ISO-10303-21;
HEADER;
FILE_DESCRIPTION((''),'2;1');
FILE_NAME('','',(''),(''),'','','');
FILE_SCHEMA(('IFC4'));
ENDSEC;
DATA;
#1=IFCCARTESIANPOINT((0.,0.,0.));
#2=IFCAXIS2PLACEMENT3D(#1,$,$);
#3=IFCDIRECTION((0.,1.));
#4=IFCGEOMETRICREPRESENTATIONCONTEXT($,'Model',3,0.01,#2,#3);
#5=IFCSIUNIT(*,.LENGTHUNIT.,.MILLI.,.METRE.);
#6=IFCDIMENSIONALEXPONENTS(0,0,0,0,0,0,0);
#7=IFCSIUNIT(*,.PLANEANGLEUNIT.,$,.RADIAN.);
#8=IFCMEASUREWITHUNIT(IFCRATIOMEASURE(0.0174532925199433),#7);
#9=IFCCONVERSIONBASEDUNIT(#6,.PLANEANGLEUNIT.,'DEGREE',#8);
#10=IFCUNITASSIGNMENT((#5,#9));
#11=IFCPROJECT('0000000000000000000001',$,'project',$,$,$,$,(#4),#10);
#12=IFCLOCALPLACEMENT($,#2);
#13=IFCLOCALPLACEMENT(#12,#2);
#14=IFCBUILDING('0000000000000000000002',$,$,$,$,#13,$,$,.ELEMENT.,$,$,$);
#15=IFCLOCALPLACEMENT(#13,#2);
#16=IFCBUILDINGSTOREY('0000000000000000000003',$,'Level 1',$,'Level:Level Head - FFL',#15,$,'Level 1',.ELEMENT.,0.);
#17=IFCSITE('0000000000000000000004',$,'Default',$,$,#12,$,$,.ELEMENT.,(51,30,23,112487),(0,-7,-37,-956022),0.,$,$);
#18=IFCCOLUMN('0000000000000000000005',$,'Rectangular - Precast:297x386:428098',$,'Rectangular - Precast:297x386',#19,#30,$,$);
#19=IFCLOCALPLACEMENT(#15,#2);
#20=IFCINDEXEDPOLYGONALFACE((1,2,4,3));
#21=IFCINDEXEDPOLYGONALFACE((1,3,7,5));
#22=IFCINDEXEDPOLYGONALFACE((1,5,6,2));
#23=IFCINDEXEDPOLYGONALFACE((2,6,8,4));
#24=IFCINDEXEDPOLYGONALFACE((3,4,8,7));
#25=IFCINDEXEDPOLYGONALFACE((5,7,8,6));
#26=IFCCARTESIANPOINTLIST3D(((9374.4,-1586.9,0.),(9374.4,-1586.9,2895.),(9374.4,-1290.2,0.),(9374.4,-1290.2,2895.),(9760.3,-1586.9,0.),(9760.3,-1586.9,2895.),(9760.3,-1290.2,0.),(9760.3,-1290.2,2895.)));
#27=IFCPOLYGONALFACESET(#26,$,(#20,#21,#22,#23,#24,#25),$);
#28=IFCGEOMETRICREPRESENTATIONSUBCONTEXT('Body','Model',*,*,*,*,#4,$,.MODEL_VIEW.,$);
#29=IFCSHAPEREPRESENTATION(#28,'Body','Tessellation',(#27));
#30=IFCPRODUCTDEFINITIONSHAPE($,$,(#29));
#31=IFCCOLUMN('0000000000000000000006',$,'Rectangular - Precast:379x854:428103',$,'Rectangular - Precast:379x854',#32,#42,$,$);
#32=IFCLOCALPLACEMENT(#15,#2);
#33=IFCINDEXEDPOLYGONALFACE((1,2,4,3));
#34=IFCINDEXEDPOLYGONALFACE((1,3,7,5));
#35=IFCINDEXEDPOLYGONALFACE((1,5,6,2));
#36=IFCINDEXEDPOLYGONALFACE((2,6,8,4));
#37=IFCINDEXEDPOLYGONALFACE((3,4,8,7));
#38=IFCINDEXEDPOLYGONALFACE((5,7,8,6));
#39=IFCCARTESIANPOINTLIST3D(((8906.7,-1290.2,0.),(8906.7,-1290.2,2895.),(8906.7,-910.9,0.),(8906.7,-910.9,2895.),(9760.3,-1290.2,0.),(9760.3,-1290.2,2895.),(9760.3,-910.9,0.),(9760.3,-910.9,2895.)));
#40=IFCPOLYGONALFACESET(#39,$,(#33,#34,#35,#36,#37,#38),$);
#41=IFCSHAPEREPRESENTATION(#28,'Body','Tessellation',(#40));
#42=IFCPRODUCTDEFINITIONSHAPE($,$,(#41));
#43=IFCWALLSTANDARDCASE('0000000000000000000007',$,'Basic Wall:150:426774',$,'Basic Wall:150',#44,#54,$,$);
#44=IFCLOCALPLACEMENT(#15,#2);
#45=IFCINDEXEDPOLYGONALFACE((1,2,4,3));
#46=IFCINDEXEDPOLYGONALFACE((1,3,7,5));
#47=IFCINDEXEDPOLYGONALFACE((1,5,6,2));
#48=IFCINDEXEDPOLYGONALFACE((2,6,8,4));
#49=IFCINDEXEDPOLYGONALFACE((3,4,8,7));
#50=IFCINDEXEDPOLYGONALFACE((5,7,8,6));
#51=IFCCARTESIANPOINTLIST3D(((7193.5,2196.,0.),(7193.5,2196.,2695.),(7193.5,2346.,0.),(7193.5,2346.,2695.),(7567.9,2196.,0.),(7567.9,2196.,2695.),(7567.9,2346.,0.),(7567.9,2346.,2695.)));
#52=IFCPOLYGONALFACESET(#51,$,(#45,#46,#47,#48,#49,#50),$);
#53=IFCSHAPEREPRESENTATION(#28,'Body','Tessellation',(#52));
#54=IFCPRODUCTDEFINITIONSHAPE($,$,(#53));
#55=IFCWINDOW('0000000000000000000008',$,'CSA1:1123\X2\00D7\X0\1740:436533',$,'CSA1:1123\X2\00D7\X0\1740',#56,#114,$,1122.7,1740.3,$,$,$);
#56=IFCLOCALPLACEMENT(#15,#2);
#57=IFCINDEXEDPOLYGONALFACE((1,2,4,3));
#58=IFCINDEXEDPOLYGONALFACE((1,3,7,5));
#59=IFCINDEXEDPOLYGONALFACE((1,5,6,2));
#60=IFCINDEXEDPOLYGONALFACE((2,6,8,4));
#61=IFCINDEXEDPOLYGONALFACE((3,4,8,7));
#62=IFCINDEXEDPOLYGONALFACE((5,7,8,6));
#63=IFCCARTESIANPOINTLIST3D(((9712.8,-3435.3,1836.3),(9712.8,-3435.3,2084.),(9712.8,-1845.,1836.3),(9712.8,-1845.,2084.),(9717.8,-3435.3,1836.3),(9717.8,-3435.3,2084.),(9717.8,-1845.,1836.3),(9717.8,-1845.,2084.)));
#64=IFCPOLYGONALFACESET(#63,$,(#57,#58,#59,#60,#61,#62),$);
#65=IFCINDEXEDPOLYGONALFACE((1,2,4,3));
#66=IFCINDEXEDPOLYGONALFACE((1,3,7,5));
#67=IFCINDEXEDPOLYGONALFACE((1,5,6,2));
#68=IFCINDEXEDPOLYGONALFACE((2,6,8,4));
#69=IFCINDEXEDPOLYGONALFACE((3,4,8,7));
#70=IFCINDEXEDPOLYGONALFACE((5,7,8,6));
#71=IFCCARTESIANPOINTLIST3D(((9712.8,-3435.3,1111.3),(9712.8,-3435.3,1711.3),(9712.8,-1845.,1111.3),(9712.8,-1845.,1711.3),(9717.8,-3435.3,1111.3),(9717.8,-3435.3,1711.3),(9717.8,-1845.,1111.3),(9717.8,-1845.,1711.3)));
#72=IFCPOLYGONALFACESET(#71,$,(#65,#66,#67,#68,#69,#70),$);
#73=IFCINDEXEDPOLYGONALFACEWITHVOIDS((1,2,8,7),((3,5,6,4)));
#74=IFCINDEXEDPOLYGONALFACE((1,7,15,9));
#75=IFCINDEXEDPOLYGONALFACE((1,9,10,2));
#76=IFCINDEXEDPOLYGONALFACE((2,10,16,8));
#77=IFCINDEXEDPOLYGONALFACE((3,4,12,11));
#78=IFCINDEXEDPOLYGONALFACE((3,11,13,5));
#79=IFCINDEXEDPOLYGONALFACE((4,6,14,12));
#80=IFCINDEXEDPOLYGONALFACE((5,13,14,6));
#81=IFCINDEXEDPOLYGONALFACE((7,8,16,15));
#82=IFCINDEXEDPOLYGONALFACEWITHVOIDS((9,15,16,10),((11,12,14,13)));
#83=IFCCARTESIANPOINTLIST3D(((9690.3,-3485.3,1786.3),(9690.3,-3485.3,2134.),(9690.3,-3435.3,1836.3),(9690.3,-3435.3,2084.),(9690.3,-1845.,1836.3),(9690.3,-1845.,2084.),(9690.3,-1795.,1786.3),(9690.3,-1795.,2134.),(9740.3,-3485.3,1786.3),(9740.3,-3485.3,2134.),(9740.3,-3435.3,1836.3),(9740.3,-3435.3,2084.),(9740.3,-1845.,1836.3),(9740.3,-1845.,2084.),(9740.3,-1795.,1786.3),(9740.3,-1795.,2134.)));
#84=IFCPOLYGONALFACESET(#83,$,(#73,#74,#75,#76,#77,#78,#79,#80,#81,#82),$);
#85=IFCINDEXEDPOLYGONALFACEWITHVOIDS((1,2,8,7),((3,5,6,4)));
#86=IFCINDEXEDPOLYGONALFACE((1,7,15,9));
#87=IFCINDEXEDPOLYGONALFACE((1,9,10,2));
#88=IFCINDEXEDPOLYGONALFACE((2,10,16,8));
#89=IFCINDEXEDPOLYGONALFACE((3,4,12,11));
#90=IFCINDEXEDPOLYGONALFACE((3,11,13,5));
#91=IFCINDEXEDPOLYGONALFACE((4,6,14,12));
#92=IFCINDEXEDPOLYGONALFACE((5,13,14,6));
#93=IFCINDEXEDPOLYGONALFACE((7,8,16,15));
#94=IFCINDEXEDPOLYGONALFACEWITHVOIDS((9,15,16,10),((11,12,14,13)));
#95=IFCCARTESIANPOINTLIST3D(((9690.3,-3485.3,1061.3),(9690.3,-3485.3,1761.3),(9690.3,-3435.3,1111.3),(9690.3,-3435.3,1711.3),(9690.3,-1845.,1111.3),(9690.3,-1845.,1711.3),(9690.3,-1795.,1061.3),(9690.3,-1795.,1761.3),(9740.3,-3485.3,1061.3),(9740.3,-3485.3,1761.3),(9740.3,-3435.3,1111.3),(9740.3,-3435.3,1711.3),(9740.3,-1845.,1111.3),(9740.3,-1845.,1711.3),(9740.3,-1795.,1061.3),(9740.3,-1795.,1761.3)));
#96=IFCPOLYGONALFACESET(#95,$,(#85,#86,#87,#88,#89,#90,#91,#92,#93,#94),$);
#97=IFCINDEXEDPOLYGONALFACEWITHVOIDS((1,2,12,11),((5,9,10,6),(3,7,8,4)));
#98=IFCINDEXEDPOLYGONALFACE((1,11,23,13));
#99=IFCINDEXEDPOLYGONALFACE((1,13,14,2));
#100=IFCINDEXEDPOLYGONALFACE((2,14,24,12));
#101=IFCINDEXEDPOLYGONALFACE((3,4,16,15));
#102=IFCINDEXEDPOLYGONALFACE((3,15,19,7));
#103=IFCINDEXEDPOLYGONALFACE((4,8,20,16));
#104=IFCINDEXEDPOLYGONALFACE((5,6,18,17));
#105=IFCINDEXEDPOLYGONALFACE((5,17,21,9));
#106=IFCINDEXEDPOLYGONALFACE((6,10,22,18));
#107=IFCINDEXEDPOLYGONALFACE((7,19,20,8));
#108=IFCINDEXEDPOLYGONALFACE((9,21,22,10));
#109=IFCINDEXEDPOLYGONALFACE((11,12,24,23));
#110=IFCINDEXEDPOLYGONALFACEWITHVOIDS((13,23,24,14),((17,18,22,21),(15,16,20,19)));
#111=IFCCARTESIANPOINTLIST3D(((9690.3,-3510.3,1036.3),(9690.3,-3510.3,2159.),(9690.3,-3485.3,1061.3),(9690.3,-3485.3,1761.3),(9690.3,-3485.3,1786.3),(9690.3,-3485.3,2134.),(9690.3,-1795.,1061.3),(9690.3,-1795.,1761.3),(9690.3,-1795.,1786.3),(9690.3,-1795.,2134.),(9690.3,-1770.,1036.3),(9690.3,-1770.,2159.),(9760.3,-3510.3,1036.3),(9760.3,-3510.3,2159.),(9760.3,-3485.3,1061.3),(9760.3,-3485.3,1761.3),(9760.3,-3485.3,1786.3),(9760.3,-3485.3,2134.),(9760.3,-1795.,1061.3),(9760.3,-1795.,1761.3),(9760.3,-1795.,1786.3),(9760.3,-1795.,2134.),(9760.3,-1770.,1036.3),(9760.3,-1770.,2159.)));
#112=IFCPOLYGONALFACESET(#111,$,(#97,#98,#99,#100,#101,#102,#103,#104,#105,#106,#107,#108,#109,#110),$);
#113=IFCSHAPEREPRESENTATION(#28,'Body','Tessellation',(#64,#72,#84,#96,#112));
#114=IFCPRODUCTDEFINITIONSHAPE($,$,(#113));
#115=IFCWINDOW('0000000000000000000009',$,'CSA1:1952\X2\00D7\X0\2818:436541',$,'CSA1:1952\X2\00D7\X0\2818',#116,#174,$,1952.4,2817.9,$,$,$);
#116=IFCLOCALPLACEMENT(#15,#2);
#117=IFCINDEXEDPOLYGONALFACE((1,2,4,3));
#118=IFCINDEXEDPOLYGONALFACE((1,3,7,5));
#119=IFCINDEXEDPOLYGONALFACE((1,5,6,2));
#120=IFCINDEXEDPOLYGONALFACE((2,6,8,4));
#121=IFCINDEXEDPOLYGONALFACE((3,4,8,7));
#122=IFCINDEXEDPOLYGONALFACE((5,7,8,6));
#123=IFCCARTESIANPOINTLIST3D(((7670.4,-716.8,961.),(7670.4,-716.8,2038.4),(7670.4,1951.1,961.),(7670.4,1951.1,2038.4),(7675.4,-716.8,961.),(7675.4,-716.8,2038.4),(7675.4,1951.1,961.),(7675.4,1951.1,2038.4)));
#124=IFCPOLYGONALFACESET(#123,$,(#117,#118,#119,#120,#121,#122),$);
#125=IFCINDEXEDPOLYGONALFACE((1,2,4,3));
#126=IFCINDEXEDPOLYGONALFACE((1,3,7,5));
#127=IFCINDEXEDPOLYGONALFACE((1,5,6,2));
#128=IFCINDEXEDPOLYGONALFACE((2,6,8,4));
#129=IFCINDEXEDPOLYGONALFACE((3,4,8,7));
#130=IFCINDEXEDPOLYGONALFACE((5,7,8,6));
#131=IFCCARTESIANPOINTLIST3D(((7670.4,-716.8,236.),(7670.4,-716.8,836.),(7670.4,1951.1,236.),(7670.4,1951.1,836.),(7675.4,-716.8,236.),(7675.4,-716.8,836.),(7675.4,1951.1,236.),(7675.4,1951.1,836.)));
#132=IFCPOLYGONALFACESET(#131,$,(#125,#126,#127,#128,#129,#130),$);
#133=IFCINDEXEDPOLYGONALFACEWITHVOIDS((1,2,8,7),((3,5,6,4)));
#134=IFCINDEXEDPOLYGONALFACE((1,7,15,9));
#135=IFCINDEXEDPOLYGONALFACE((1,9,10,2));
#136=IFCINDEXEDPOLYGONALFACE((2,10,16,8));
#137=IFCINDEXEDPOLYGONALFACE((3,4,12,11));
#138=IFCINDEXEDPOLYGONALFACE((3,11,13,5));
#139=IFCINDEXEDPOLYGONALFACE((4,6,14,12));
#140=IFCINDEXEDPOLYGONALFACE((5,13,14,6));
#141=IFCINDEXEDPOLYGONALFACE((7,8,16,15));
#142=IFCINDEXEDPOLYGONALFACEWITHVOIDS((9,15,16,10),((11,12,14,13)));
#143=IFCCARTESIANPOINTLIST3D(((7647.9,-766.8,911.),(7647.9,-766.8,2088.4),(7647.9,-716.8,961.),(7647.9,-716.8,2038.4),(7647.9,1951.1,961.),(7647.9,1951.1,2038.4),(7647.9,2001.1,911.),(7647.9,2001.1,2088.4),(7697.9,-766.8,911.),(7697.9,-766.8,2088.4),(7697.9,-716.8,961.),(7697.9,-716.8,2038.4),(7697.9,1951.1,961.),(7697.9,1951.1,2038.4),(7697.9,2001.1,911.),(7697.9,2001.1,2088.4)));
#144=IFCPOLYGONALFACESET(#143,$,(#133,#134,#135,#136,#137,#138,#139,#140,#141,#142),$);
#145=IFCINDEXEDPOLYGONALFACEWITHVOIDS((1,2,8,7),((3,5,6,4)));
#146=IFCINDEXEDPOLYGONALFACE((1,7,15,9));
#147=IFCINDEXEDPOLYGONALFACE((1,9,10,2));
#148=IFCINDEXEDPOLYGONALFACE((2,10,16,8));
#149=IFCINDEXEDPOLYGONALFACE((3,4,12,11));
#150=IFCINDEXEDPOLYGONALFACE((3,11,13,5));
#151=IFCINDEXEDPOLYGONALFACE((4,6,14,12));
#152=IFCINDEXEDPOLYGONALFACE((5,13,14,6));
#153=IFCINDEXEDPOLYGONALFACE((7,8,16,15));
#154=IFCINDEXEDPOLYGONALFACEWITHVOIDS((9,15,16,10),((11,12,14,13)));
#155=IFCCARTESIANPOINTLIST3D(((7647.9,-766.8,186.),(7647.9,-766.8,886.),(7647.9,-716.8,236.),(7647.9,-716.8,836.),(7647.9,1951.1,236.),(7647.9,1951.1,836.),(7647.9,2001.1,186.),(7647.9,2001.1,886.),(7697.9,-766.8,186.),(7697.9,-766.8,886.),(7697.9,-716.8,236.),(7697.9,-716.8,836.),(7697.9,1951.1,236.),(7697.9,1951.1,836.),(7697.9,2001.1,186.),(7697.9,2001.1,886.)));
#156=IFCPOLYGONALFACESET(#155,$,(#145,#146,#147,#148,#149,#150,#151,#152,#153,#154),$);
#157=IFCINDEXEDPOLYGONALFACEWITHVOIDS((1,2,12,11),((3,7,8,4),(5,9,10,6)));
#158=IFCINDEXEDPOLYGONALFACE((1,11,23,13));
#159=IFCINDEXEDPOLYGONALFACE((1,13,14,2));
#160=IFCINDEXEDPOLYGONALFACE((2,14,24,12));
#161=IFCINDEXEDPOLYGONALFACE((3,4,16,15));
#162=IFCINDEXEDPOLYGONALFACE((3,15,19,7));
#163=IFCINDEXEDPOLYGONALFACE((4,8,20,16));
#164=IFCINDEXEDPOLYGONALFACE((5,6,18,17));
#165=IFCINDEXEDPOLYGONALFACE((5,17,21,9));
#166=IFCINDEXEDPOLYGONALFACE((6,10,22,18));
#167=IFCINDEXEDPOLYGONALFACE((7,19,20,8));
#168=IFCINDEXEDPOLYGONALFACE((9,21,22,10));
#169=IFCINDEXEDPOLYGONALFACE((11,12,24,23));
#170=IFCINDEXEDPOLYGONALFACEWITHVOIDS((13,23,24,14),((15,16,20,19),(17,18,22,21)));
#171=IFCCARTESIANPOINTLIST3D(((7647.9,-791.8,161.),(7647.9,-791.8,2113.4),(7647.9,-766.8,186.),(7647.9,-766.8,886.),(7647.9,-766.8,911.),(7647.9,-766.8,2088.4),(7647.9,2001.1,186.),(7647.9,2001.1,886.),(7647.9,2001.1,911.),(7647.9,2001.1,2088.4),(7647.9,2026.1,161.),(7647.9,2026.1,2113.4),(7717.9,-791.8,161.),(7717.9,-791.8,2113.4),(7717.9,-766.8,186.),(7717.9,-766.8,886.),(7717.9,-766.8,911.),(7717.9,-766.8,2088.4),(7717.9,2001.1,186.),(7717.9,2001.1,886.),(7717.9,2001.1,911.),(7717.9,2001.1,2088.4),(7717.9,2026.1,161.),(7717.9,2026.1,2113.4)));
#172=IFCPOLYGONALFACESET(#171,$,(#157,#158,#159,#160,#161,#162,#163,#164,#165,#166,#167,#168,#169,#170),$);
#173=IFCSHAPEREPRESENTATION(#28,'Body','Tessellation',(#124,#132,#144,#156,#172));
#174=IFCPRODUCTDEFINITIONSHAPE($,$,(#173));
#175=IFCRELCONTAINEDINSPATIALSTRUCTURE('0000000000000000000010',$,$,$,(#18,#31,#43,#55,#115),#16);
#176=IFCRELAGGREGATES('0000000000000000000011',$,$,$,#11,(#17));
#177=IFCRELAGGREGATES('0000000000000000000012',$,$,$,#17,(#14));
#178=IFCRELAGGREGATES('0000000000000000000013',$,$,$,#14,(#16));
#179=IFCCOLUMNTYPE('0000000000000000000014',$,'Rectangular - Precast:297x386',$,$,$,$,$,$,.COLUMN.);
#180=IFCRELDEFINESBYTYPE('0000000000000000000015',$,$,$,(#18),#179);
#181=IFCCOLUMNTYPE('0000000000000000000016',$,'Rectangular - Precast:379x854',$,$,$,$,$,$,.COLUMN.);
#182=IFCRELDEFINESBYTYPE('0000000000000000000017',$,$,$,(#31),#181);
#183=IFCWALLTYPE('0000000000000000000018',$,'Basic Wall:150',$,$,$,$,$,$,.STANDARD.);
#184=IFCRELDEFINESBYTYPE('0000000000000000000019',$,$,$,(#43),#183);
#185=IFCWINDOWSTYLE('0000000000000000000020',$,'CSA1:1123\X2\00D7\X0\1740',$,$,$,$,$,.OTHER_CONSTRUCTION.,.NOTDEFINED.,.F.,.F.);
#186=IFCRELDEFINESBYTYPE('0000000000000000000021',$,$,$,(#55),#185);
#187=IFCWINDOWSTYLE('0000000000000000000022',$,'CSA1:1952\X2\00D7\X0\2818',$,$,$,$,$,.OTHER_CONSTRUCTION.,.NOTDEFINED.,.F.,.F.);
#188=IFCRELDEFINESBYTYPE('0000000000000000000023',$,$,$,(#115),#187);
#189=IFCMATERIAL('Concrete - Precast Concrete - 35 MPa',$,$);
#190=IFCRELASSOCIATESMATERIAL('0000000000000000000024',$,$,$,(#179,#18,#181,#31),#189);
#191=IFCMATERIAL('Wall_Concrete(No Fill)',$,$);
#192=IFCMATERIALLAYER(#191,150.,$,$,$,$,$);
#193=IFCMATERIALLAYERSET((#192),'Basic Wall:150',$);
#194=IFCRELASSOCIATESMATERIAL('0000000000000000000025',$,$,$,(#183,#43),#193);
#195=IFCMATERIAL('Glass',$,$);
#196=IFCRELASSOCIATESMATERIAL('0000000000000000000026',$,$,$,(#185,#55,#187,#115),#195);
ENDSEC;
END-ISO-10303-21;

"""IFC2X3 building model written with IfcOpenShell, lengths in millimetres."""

from ifc_helpers import new_model, entity, si_unit, converted_unit, direction, frame, frame_2d, origin, origin_2d_with_axis, place, context, subcontext, project, spatial, polyline, rectangle, outline, extrude, source, transform, mapped, material, layer, layer_set, layer_usage, type_object, type_shapes, element, save


model = new_model("IFC2X3")

# Units and contexts
model_context = context("Model", 3, precision=0.01, world=origin(), true_north=direction((0.0, 1.0)))
body_context = subcontext(model_context, "Body", "Model", "MODEL_VIEW")
ifc_project = project(units=[si_unit("LENGTHUNIT", "METRE", prefix="MILLI"), converted_unit("PLANEANGLEUNIT", "DEGREE", entity("IfcRatioMeasure", 0.0174532925199433), si_unit("PLANEANGLEUNIT", "RADIAN"), dimensions=[0, 0, 0, 0, 0, 0, 0])], contexts=[model_context])

# Site, building, storey
site_placement = place(None, origin())
site = spatial("IfcSite", under=ifc_project, at=site_placement, Name="Default", CompositionType="ELEMENT", RefLatitude=(51, 30, 23, 112487), RefLongitude=(0, -7, -37, -956022), RefElevation=0.0)
building_placement = place(site_placement, origin())
building = spatial("IfcBuilding", under=site, at=building_placement, CompositionType="ELEMENT")
storey_placement = place(building_placement, origin())
storey = spatial("IfcBuildingStorey", under=building, at=storey_placement, Name="Level 1", ObjectType="Level:Level Head - FFL", LongName="Level 1", CompositionType="ELEMENT", Elevation=0.0)

# Columns
ifc_material_1 = material(Name="Concrete - Precast Concrete - 35 MPa")
column_type_1 = type_object("IfcColumnType", Name="Rectangular - Precast:297x386", PredefinedType="COLUMN", material=ifc_material_1)
shared_shape_1 = source(origin(), body_context, "Body", "SweptSolid", [
    extrude(rectangle(XDim=385.9, YDim=296.7, at=frame_2d((0.0, 0.0), x_axis=(1.0, 0.0))), frame((0.0, 0.0, 0.0), z_axis=(0.0, 0.0, 1.0), x_axis=(0.0, -1.0, 0.0)), (0.0, 0.0, 1.0), 2895.0),
])
type_shapes(column_type_1, [shared_shape_1])
column_1_placement = place(storey_placement, frame((9567.3, -1438.5, 0.0), z_axis=(0.0, 0.0, 1.0), x_axis=(-0.000004, 1.0, 0.0)))
element("IfcColumn", 1, at=column_1_placement, inside=storey, type_object=column_type_1, material=ifc_material_1, Name="Rectangular - Precast:297x386:428098", ObjectType="Rectangular - Precast:297x386", context=body_context, shape_type="MappedRepresentation", body=[
    mapped(shared_shape_1, transform((0.0, 0.0, 0.0), scale=1.0)),
])
column_type_2 = type_object("IfcColumnType", Name="Rectangular - Precast:379x854", PredefinedType="COLUMN", material=ifc_material_1)
shared_shape_2 = source(origin(), body_context, "Body", "SweptSolid", [
    extrude(rectangle(XDim=853.6, YDim=379.3, at=frame_2d((0.0, 0.0), x_axis=(1.0, 0.0))), frame((0.0, 0.0, 0.0), z_axis=(0.0, 0.0, 1.0), x_axis=(0.0, -1.0, 0.0)), (0.0, 0.0, 1.0), 2895.0),
])
type_shapes(column_type_2, [shared_shape_2])
column_2_placement = place(storey_placement, frame((9333.5, -1100.6, 0.0), z_axis=(0.0, 0.0, 1.0), x_axis=(-0.000004, 1.0, 0.0)))
element("IfcColumn", 2, at=column_2_placement, inside=storey, type_object=column_type_2, material=ifc_material_1, Name="Rectangular - Precast:379x854:428103", ObjectType="Rectangular - Precast:379x854", context=body_context, shape_type="MappedRepresentation", body=[
    mapped(shared_shape_2, transform((0.0, 0.0, 0.0), scale=1.0)),
])

# Shared definitions
ifc_material_2 = material(Name="Wall_Concrete(No Fill)")
ifc_layer = layer(ifc_material_2, 150.0)
ifc_layer_set = layer_set([ifc_layer], Name="Basic Wall:150")
wall_type = type_object("IfcWallType", Name="Basic Wall:150", PredefinedType="STANDARD", material=ifc_layer_set)

# Wall
ifc_layer_usage_1 = layer_usage(ifc_layer_set, "AXIS2", "NEGATIVE", 75.0)
wall_1_placement = place(storey_placement, frame((7193.5, 2271.0, 0.0)))
element("IfcWallStandardCase", 3, at=wall_1_placement, inside=storey, type_object=wall_type, material=ifc_layer_usage_1, Name="Basic Wall:150:426774", ObjectType="Basic Wall:150", context=body_context, shape_type="SweptSolid", body=[
    extrude(rectangle(XDim=374.4, YDim=150.0, at=frame_2d((187.2, 0.0), x_axis=(-1.0, 0.0))), origin(), (0.0, 0.0, 1.0), 2695.0),
])

# Windows
ifc_material_3 = material(Name="Glass")
window_style_1 = type_object("IfcWindowStyle", Name="CSA1:1123×1740", ConstructionType="OTHER_CONSTRUCTION", OperationType="NOTDEFINED", ParameterTakesPrecedence=False, Sizeable=False, material=ifc_material_3)
shared_shape_3 = source(origin(), body_context, "Body", "SweptSolid", [
    extrude(rectangle(XDim=5.0, YDim=1590.3, at=frame_2d((0.0, 0.0), x_axis=(1.0, 0.0))), frame((870.2, 45.0, 800.0), z_axis=(0.0, 0.0, 1.0), x_axis=(0.0, 1.0, 0.0)), (0.0, 0.0, 1.0), 247.7),
    extrude(rectangle(XDim=5.0, YDim=1590.3, at=frame_2d((0.0, 0.0), x_axis=(1.0, 0.0))), frame((870.2, 45.0, 75.0), z_axis=(0.0, 0.0, 1.0), x_axis=(0.0, 1.0, 0.0)), (0.0, 0.0, 1.0), 600.0),
    extrude(outline(polyline([(-845.2, -173.9), (845.2, -173.9), (845.2, 173.9), (-845.2, 173.9), (-845.2, -173.9)]), holes=[polyline([(-795.2, -123.9), (-795.2, 123.9), (795.2, 123.9), (795.2, -123.9), (-795.2, -123.9)])]), frame((870.2, 20.0, 923.9), z_axis=(0.0, 1.0, 0.0), x_axis=(1.0, 0.0, 0.0)), (0.0, 0.0, 1.0), 50.0),
    extrude(outline(polyline([(-845.2, -350.0), (845.2, -350.0), (845.2, 350.0), (-845.2, 350.0), (-845.2, -350.0)]), holes=[polyline([(-795.2, -300.0), (-795.2, 300.0), (795.2, 300.0), (795.2, -300.0), (-795.2, -300.0)])]), frame((870.2, 20.0, 375.0), z_axis=(0.0, 1.0, 0.0), x_axis=(1.0, 0.0, 0.0)), (0.0, 0.0, 1.0), 50.0),
    extrude(outline(polyline([(-870.2, -561.4), (870.2, -561.4), (870.2, 561.4), (-870.2, 561.4), (-870.2, -561.4)]), holes=[polyline([(-845.2, -536.4), (-845.2, -188.6), (845.2, -188.6), (845.2, -536.4), (-845.2, -536.4)]), polyline([(-845.2, -163.6), (-845.2, 536.4), (845.2, 536.4), (845.2, -163.6), (-845.2, -163.6)])]), frame((870.2, 0.0, 561.4), z_axis=(0.0, 1.0, 0.0), x_axis=(1.0, 0.0, 0.0)), (0.0, 0.0, 1.0), 70.0),
])
type_shapes(window_style_1, [shared_shape_3])
window_1_placement = place(storey_placement, frame((9760.3, -3510.3, 1036.3), z_axis=(0.0, 0.0, 1.0), x_axis=(0.0, 1.0, 0.0)))
element("IfcWindow", 4, at=window_1_placement, inside=storey, type_object=window_style_1, material=ifc_material_3, Name="CSA1:1123×1740:436533", ObjectType="CSA1:1123×1740", OverallHeight=1122.7, OverallWidth=1740.3, context=body_context, shape_type="MappedRepresentation", body=[
    mapped(shared_shape_3, transform((0.0, 0.0, 0.0), scale=1.0)),
])
window_style_2 = type_object("IfcWindowStyle", Name="CSA1:1952×2818", ConstructionType="OTHER_CONSTRUCTION", OperationType="NOTDEFINED", ParameterTakesPrecedence=False, Sizeable=False, material=ifc_material_3)
shared_shape_4 = source(origin(), body_context, "Body", "SweptSolid", [
    extrude(rectangle(XDim=5.0, YDim=2667.9, at=origin_2d_with_axis()), frame((1409.0, 45.0, 800.0), z_axis=(0.0, 0.0, 1.0), x_axis=(0.0, 1.0, 0.0)), (0.0, 0.0, 1.0), 1077.4),
    extrude(rectangle(XDim=5.0, YDim=2667.9, at=origin_2d_with_axis()), frame((1409.0, 45.0, 75.0), z_axis=(0.0, 0.0, 1.0), x_axis=(0.0, 1.0, 0.0)), (0.0, 0.0, 1.0), 600.0),
    extrude(outline(polyline([(-1384.0, -588.7), (1384.0, -588.7), (1384.0, 588.7), (-1384.0, 588.7), (-1384.0, -588.7)]), holes=[polyline([(-1334.0, -538.7), (-1334.0, 538.7), (1334.0, 538.7), (1334.0, -538.7), (-1334.0, -538.7)])]), frame((1409.0, 20.0, 1338.7), z_axis=(0.0, 1.0, 0.0), x_axis=(1.0, 0.0, 0.0)), (0.0, 0.0, 1.0), 50.0),
    extrude(outline(polyline([(-1384.0, -350.0), (1384.0, -350.0), (1384.0, 350.0), (-1384.0, 350.0), (-1384.0, -350.0)]), holes=[polyline([(-1334.0, -300.0), (-1334.0, 300.0), (1334.0, 300.0), (1334.0, -300.0), (-1334.0, -300.0)])]), frame((1409.0, 20.0, 375.0), z_axis=(0.0, 1.0, 0.0), x_axis=(1.0, 0.0, 0.0)), (0.0, 0.0, 1.0), 50.0),
    extrude(outline(polyline([(-1409.0, -976.2), (1409.0, -976.2), (1409.0, 976.2), (-1409.0, 976.2), (-1409.0, -976.2)]), holes=[polyline([(-1384.0, -951.2), (-1384.0, 226.2), (1384.0, 226.2), (1384.0, -951.2), (-1384.0, -951.2)]), polyline([(-1384.0, 251.2), (-1384.0, 951.2), (1384.0, 951.2), (1384.0, 251.2), (-1384.0, 251.2)])]), frame((1409.0, 0.0, 976.2), z_axis=(0.0, 1.0, 0.0), x_axis=(1.0, 0.0, 0.0)), (0.0, 0.0, 1.0), 70.0),
])
type_shapes(window_style_2, [shared_shape_4])
window_2_placement = place(storey_placement, frame((7717.9, -791.8, 161.0), z_axis=(0.0, 0.0, 1.0), x_axis=(0.0, 1.0, 0.0)))
element("IfcWindow", 5, at=window_2_placement, inside=storey, type_object=window_style_2, material=ifc_material_3, Name="CSA1:1952×2818:436541", ObjectType="CSA1:1952×2818", OverallHeight=1952.4, OverallWidth=2817.9, context=body_context, shape_type="MappedRepresentation", body=[
    mapped(shared_shape_4, transform((0.0, 0.0, 0.0), scale=1.0)),
])

save(model, "model.ifc")
